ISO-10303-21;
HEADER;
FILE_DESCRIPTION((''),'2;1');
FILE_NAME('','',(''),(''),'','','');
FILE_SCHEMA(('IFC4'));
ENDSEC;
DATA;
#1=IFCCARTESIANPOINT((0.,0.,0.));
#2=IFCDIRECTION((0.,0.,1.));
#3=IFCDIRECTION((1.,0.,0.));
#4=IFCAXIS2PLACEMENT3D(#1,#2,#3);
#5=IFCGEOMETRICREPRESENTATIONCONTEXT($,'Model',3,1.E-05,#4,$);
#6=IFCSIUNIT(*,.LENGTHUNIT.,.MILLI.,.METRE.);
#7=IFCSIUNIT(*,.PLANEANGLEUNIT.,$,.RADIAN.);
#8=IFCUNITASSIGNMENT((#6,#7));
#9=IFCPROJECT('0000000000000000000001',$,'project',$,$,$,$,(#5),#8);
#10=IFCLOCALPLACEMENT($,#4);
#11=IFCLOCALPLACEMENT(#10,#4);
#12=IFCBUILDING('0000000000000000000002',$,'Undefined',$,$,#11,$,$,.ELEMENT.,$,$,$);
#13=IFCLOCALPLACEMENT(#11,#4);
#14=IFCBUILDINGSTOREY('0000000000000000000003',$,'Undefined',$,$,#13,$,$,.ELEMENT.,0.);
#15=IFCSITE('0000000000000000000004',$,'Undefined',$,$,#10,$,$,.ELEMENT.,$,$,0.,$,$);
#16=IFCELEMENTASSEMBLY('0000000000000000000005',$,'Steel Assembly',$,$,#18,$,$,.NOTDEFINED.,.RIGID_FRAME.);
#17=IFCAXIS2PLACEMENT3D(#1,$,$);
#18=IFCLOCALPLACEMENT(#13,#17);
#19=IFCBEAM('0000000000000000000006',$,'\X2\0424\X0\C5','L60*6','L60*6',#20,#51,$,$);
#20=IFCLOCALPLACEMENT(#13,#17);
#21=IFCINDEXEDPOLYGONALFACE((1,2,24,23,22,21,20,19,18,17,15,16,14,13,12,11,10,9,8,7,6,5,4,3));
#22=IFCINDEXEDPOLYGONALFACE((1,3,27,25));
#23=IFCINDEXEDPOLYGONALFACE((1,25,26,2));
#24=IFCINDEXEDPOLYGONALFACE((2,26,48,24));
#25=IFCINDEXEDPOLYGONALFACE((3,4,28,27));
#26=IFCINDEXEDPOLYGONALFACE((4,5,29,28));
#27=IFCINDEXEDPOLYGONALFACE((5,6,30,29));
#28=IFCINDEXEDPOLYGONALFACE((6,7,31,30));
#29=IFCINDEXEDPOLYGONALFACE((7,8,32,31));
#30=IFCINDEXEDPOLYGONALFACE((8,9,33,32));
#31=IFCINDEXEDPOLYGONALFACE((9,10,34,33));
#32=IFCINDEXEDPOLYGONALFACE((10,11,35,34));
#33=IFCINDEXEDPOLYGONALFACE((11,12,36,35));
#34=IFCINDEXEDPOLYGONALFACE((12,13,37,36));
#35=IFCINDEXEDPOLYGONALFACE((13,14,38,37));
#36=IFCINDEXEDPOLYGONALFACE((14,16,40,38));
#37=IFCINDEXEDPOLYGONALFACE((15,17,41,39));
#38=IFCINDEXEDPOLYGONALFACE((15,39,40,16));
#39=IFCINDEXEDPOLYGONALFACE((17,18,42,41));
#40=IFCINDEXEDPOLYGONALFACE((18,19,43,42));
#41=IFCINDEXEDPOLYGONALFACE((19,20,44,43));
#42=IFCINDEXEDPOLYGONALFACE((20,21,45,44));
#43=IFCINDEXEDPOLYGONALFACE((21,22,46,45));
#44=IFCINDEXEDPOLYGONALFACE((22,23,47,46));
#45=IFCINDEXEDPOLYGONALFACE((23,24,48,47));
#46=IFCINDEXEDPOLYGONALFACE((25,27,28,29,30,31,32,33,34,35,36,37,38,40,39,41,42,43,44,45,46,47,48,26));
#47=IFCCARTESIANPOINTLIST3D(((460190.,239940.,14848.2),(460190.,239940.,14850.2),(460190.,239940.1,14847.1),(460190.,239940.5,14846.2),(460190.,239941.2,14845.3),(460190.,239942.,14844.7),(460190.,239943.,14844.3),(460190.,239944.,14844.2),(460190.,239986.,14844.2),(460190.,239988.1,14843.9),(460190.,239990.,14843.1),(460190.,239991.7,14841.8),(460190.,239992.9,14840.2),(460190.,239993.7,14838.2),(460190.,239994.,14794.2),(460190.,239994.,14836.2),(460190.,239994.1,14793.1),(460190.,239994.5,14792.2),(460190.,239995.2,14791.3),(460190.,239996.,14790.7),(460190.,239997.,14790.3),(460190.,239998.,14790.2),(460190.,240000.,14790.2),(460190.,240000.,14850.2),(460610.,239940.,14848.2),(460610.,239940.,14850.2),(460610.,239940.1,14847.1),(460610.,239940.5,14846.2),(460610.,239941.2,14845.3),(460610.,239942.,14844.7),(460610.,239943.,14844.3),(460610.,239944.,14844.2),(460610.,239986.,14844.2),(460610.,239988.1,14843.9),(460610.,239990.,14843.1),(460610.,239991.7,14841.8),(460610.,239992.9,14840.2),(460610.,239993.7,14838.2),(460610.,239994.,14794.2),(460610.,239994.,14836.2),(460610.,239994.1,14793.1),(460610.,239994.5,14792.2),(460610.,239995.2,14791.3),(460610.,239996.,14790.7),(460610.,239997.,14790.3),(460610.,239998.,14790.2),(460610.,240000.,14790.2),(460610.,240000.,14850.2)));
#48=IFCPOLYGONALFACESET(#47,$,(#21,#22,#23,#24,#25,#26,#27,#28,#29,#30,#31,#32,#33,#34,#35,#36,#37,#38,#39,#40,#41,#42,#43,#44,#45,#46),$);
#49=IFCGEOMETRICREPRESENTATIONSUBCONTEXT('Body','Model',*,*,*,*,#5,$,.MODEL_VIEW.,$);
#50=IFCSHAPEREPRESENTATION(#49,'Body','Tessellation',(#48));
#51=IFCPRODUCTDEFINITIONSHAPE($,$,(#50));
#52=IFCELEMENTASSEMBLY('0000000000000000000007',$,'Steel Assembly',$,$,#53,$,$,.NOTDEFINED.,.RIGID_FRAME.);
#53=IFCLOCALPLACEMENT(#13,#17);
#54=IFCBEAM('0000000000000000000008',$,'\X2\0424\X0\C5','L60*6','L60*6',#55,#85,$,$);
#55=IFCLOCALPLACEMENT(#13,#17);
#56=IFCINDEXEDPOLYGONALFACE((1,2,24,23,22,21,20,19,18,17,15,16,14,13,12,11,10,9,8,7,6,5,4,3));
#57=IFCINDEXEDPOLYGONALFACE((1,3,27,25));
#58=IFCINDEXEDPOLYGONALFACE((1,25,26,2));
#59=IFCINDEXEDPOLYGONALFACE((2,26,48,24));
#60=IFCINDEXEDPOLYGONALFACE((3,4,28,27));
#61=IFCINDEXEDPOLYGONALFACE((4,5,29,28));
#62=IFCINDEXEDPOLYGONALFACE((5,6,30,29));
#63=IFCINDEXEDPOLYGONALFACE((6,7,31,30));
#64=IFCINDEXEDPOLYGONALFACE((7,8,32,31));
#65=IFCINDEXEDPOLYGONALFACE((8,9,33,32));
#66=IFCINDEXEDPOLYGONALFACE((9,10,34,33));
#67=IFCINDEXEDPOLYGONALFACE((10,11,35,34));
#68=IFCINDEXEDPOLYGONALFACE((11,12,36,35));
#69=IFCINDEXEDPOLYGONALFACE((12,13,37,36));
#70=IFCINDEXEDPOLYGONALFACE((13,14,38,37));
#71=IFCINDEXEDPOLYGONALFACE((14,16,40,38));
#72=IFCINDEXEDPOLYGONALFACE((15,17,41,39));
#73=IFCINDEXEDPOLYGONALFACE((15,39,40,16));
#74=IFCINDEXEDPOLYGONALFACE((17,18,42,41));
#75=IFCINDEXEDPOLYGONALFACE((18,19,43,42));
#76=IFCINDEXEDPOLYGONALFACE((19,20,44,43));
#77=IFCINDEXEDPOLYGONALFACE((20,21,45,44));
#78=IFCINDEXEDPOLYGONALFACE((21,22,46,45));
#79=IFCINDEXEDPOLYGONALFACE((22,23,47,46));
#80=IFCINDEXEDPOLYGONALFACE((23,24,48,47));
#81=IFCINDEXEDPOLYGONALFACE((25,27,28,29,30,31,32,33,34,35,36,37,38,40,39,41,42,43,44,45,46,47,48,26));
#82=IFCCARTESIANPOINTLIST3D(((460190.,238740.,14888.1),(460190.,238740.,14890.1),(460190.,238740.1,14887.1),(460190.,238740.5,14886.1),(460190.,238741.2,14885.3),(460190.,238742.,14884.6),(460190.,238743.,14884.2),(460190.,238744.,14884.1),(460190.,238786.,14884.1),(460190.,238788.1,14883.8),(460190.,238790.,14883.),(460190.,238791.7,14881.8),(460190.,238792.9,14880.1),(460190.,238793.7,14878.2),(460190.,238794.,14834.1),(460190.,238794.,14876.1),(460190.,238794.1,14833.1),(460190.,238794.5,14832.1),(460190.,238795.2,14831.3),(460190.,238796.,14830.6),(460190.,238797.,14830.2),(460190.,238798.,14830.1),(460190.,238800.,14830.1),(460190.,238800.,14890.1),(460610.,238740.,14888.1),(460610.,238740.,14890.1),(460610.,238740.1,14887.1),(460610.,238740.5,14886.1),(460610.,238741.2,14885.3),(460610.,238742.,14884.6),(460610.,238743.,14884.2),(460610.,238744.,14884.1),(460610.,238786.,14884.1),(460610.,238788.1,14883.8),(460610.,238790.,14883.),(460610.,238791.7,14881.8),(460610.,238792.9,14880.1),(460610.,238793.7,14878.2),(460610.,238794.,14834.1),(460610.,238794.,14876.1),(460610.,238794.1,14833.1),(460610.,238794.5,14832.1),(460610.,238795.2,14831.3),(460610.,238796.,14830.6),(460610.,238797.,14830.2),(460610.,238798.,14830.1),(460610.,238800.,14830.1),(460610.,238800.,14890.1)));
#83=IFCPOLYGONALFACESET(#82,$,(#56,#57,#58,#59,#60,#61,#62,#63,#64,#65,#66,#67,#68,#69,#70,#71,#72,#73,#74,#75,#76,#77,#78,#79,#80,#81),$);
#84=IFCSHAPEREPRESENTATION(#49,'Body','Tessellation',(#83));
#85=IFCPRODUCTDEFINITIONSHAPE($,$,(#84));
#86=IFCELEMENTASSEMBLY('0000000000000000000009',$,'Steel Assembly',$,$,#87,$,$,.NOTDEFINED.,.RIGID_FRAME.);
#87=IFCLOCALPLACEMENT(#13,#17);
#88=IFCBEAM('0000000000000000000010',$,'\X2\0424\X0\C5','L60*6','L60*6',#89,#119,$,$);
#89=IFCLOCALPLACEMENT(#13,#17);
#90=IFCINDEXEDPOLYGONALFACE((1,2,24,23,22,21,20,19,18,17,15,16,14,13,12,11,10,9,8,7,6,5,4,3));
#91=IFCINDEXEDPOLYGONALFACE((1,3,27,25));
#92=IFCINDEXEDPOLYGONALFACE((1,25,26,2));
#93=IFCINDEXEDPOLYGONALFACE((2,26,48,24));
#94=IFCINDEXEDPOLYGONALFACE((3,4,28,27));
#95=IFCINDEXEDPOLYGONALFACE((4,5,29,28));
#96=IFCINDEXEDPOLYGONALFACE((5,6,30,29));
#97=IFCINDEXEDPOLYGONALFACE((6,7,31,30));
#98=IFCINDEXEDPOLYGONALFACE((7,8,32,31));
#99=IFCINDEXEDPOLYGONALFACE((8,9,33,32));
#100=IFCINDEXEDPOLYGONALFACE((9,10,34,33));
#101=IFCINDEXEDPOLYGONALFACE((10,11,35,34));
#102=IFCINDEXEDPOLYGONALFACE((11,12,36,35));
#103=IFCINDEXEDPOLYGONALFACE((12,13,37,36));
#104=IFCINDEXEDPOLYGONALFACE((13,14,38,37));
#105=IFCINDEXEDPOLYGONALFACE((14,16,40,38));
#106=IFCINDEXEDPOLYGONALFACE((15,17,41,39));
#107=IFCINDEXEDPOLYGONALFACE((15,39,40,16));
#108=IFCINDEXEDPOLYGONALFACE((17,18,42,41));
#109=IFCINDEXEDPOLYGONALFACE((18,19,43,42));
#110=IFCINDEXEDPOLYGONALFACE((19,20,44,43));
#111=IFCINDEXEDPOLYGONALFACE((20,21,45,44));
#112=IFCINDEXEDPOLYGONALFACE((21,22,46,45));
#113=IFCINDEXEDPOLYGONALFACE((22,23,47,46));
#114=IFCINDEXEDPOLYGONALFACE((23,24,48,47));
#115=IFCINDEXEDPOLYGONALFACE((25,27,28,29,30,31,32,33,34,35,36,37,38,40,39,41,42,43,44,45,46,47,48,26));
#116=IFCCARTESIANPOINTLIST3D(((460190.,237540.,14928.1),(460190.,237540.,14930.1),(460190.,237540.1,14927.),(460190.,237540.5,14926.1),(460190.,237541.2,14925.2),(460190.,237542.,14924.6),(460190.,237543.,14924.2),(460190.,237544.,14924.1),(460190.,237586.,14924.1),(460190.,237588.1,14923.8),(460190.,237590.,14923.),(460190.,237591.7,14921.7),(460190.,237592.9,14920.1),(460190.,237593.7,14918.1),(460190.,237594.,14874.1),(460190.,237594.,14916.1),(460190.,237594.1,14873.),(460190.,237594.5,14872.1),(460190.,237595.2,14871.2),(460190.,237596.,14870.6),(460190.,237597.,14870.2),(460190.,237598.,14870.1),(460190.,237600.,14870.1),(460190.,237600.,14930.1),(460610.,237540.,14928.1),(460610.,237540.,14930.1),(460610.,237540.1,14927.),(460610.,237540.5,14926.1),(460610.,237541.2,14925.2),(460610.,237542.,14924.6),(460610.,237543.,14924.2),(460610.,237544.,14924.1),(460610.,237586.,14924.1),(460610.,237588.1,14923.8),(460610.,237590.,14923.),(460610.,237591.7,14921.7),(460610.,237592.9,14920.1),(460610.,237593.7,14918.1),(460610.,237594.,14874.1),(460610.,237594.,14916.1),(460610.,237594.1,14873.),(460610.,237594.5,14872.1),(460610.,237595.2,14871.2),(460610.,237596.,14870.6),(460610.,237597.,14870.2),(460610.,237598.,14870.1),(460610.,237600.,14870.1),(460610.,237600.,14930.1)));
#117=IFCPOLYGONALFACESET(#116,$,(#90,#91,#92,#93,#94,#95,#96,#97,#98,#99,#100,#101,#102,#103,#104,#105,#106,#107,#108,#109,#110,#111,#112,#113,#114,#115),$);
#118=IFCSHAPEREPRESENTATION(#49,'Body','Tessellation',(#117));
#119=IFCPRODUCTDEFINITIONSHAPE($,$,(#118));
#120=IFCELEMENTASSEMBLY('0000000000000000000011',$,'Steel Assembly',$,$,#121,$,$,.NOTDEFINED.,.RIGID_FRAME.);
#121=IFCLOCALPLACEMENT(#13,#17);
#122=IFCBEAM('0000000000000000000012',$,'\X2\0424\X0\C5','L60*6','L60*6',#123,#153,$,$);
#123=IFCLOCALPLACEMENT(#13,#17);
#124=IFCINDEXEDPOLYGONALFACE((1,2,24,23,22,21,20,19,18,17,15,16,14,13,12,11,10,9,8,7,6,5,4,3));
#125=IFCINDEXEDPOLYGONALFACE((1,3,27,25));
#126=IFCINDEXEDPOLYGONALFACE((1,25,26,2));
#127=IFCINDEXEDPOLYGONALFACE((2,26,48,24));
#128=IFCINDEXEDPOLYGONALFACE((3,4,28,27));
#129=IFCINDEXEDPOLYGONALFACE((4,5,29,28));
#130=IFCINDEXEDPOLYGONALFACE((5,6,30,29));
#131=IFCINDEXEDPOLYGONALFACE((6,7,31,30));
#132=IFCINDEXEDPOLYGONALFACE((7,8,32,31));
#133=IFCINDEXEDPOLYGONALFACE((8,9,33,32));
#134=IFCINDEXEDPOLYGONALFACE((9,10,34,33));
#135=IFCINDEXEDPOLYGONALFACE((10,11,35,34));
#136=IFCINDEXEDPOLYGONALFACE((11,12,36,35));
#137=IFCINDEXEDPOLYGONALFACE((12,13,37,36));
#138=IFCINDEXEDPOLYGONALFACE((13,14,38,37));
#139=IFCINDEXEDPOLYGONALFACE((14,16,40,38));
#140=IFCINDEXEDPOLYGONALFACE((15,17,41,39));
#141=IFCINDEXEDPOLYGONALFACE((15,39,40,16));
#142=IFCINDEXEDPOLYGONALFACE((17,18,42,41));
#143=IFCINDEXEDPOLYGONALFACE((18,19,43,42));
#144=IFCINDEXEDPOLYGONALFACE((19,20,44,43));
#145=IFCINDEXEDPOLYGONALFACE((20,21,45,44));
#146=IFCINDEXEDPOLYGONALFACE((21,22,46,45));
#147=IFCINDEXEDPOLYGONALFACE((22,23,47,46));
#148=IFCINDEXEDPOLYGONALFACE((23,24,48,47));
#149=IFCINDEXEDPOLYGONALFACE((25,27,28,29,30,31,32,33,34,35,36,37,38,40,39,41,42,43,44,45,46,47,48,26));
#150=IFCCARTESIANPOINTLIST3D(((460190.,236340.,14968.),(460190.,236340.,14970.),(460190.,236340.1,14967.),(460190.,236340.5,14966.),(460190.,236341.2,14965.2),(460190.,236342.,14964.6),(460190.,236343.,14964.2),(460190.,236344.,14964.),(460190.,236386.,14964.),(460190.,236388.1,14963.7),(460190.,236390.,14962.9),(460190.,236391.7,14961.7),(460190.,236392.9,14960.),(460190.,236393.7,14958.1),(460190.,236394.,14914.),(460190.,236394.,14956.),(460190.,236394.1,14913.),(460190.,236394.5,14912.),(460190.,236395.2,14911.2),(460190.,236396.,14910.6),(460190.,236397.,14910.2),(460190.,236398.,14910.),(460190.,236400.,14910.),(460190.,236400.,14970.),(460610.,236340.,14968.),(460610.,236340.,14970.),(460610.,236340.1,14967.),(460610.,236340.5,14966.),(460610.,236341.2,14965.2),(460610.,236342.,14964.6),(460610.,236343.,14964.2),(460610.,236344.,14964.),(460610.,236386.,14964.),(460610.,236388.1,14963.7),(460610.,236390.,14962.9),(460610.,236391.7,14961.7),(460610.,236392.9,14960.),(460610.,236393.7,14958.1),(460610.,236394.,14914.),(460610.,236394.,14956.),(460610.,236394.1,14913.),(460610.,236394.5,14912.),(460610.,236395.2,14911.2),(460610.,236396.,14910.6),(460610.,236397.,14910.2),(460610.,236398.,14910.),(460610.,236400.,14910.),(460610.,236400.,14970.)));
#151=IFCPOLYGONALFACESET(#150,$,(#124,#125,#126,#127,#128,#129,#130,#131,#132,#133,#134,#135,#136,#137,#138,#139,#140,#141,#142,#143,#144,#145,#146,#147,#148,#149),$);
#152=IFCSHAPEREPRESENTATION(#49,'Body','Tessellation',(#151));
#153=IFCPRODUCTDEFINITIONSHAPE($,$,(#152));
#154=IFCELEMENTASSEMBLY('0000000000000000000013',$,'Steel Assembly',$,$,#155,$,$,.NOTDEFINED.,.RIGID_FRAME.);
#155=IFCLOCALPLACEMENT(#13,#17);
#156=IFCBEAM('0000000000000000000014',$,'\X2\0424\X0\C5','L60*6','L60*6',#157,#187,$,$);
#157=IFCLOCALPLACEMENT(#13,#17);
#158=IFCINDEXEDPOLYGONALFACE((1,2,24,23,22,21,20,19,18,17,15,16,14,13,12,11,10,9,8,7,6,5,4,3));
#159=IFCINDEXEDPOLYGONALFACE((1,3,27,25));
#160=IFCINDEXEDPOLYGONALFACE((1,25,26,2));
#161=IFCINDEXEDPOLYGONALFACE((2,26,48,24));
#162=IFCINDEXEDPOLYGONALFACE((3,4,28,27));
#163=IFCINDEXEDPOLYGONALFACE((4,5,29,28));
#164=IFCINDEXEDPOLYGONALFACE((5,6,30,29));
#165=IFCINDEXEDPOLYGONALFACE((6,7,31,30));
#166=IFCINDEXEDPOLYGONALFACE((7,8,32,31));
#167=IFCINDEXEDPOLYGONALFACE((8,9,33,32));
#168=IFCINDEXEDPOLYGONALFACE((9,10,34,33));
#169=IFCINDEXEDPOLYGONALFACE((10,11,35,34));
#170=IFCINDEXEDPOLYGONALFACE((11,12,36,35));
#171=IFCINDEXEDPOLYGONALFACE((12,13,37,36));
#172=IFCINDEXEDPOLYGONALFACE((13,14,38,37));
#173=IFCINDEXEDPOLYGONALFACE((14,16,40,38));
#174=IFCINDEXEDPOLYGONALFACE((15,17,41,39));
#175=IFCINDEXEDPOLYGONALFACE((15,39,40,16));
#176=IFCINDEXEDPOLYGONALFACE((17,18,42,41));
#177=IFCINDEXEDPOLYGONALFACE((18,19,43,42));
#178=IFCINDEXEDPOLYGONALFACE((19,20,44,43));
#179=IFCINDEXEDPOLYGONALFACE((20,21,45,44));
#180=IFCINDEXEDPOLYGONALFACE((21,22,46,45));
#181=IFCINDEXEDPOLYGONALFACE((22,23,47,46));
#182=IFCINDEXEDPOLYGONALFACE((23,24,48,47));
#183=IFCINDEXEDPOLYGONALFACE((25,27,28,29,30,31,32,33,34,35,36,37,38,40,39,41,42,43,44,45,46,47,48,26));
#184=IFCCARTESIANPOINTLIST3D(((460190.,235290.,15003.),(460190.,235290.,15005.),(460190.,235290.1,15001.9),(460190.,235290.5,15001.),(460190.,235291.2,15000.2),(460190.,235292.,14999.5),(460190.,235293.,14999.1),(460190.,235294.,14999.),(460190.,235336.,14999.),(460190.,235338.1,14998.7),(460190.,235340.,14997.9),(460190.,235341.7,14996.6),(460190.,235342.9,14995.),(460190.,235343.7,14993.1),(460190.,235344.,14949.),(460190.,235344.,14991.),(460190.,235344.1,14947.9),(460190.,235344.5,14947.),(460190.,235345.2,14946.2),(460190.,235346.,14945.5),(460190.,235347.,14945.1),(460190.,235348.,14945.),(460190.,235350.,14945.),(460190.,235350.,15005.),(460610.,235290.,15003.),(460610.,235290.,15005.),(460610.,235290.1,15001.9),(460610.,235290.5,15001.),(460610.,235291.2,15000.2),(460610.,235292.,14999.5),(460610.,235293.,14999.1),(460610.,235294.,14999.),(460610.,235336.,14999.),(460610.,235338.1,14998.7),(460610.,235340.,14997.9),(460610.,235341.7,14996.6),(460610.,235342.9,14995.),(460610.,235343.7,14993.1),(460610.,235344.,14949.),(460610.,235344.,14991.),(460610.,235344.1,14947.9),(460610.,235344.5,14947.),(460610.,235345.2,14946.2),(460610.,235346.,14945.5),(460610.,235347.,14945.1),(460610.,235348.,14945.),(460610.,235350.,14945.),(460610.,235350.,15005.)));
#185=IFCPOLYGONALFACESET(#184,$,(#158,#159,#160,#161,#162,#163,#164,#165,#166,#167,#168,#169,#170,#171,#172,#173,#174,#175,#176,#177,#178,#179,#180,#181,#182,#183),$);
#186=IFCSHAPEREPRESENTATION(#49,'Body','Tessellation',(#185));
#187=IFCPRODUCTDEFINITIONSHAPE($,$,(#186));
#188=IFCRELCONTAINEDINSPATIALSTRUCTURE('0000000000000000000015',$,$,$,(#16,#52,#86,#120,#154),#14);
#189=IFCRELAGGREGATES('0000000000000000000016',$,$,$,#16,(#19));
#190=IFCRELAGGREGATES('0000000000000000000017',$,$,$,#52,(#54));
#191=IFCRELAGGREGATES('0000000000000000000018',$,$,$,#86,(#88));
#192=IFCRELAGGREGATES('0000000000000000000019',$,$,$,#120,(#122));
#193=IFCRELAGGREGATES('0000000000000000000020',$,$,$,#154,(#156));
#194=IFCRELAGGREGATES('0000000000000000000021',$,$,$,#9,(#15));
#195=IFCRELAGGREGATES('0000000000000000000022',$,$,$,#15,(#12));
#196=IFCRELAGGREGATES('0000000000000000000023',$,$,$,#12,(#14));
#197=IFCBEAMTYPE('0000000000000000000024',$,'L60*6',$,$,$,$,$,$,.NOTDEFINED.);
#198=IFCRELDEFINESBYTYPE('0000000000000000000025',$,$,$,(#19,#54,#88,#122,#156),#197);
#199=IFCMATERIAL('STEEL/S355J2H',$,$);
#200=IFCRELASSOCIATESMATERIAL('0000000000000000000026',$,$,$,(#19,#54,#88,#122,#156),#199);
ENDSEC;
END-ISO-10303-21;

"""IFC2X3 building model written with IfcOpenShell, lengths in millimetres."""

from ifc_helpers import new_model, si_unit, frame, origin_with_axes, origin_2d_with_axis, place, context, subcontext, project, spatial, l_section, extrude, material, type_object, element, aggregate, save


model = new_model("IFC2X3")

# Units and contexts
model_context = context("Model", 3, precision=1e-05, world=origin_with_axes())
body_context = subcontext(model_context, "Body", "Model", "MODEL_VIEW")
ifc_project = project(units=[si_unit("LENGTHUNIT", "METRE", prefix="MILLI"), si_unit("PLANEANGLEUNIT", "RADIAN")], contexts=[model_context])

# Site, building, storey
site_placement = place(None, origin_with_axes())
site = spatial("IfcSite", under=ifc_project, at=site_placement, Name="Undefined", CompositionType="ELEMENT", RefElevation=0.0)
building_placement = place(site_placement, origin_with_axes())
building = spatial("IfcBuilding", under=site, at=building_placement, Name="Undefined", CompositionType="ELEMENT")
storey_placement = place(building_placement, origin_with_axes())
storey = spatial("IfcBuildingStorey", under=building, at=storey_placement, Name="Undefined", CompositionType="ELEMENT", Elevation=0.0)

# Element assemblies, beams
ifc_material_1 = material(Name="STEEL/S355J2H")
assembly_1_placement = place(storey_placement, origin_with_axes())
assembly_1 = element("IfcElementAssembly", 1, at=assembly_1_placement, inside=storey, Name="Steel Assembly", AssemblyPlace="NOTDEFINED", PredefinedType="RIGID_FRAME")
beam_type_1 = type_object("IfcBeamType", Name="L60*6", PredefinedType="NOTDEFINED")
beam_1_placement = place(assembly_1_placement, frame((460190.0, 239970.0, 14820.1), z_axis=(0.0, -1.0, 0.0), x_axis=(1.0, 0.0, 0.0)))
beam_1 = element("IfcBeam", 2, at=beam_1_placement, type_object=beam_type_1, material=ifc_material_1, Name="ФC5", Description="L60*6", ObjectType="L60*6", context=body_context, shape_type="SweptSolid", body=[
    extrude(l_section(Depth=60.0, Width=60.0, Thickness=6.0, FilletRadius=8.0, EdgeRadius=4.0, at=origin_2d_with_axis()), frame((420.0, 0.0, 0.0), z_axis=(-1.0, 0.0, 0.0), x_axis=(0.0, -1.0, 0.0)), (0.0, 0.0, 1.0), 420.0),
])
aggregate(assembly_1, [beam_1])
assembly_2_placement = place(storey_placement, origin_with_axes())
assembly_2 = element("IfcElementAssembly", 3, at=assembly_2_placement, inside=storey, Name="Steel Assembly", AssemblyPlace="NOTDEFINED", PredefinedType="RIGID_FRAME")
beam_2_placement = place(assembly_2_placement, frame((460190.0, 238770.0, 14860.1), z_axis=(0.0, -1.0, 0.0), x_axis=(1.0, 0.0, 0.0)))
beam_2 = element("IfcBeam", 4, at=beam_2_placement, type_object=beam_type_1, material=ifc_material_1, Name="ФC5", Description="L60*6", ObjectType="L60*6", context=body_context, shape_type="SweptSolid", body=[
    extrude(l_section(Depth=60.0, Width=60.0, Thickness=6.0, FilletRadius=8.0, EdgeRadius=4.0, at=origin_2d_with_axis()), frame((420.0, 0.0, 0.0), z_axis=(-1.0, 0.0, 0.0), x_axis=(0.0, -1.0, 0.0)), (0.0, 0.0, 1.0), 420.0),
])
aggregate(assembly_2, [beam_2])
assembly_3_placement = place(storey_placement, origin_with_axes())
assembly_3 = element("IfcElementAssembly", 5, at=assembly_3_placement, inside=storey, Name="Steel Assembly", AssemblyPlace="NOTDEFINED", PredefinedType="RIGID_FRAME")
beam_3_placement = place(assembly_3_placement, frame((460190.0, 237570.0, 14900.1), z_axis=(0.0, -1.0, 0.0), x_axis=(1.0, 0.0, 0.0)))
beam_3 = element("IfcBeam", 6, at=beam_3_placement, type_object=beam_type_1, material=ifc_material_1, Name="ФC5", Description="L60*6", ObjectType="L60*6", context=body_context, shape_type="SweptSolid", body=[
    extrude(l_section(Depth=60.0, Width=60.0, Thickness=6.0, FilletRadius=8.0, EdgeRadius=4.0, at=origin_2d_with_axis()), frame((420.0, 0.0, 0.0), z_axis=(-1.0, 0.0, 0.0), x_axis=(0.0, -1.0, 0.0)), (0.0, 0.0, 1.0), 420.0),
])
aggregate(assembly_3, [beam_3])
assembly_4_placement = place(storey_placement, origin_with_axes())
assembly_4 = element("IfcElementAssembly", 7, at=assembly_4_placement, inside=storey, Name="Steel Assembly", AssemblyPlace="NOTDEFINED", PredefinedType="RIGID_FRAME")
beam_4_placement = place(assembly_4_placement, frame((460190.0, 236370.0, 14940.0), z_axis=(0.0, -1.0, 0.0), x_axis=(1.0, 0.0, 0.0)))
beam_4 = element("IfcBeam", 8, at=beam_4_placement, type_object=beam_type_1, material=ifc_material_1, Name="ФC5", Description="L60*6", ObjectType="L60*6", context=body_context, shape_type="SweptSolid", body=[
    extrude(l_section(Depth=60.0, Width=60.0, Thickness=6.0, FilletRadius=8.0, EdgeRadius=4.0, at=origin_2d_with_axis()), frame((420.0, 0.0, 0.0), z_axis=(-1.0, 0.0, 0.0), x_axis=(0.0, -1.0, 0.0)), (0.0, 0.0, 1.0), 420.0),
])
aggregate(assembly_4, [beam_4])
assembly_5_placement = place(storey_placement, origin_with_axes())
assembly_5 = element("IfcElementAssembly", 9, at=assembly_5_placement, inside=storey, Name="Steel Assembly", AssemblyPlace="NOTDEFINED", PredefinedType="RIGID_FRAME")
beam_5_placement = place(assembly_5_placement, frame((460190.0, 235320.0, 14975.0), z_axis=(0.0, -1.0, 0.0), x_axis=(1.0, 0.0, 0.0)))
beam_5 = element("IfcBeam", 10, at=beam_5_placement, type_object=beam_type_1, material=ifc_material_1, Name="ФC5", Description="L60*6", ObjectType="L60*6", context=body_context, shape_type="SweptSolid", body=[
    extrude(l_section(Depth=60.0, Width=60.0, Thickness=6.0, FilletRadius=8.0, EdgeRadius=4.0, at=origin_2d_with_axis()), frame((420.0, 0.0, 0.0), z_axis=(-1.0, 0.0, 0.0), x_axis=(0.0, -1.0, 0.0)), (0.0, 0.0, 1.0), 420.0),
])
aggregate(assembly_5, [beam_5])

save(model, "model.ifc")
